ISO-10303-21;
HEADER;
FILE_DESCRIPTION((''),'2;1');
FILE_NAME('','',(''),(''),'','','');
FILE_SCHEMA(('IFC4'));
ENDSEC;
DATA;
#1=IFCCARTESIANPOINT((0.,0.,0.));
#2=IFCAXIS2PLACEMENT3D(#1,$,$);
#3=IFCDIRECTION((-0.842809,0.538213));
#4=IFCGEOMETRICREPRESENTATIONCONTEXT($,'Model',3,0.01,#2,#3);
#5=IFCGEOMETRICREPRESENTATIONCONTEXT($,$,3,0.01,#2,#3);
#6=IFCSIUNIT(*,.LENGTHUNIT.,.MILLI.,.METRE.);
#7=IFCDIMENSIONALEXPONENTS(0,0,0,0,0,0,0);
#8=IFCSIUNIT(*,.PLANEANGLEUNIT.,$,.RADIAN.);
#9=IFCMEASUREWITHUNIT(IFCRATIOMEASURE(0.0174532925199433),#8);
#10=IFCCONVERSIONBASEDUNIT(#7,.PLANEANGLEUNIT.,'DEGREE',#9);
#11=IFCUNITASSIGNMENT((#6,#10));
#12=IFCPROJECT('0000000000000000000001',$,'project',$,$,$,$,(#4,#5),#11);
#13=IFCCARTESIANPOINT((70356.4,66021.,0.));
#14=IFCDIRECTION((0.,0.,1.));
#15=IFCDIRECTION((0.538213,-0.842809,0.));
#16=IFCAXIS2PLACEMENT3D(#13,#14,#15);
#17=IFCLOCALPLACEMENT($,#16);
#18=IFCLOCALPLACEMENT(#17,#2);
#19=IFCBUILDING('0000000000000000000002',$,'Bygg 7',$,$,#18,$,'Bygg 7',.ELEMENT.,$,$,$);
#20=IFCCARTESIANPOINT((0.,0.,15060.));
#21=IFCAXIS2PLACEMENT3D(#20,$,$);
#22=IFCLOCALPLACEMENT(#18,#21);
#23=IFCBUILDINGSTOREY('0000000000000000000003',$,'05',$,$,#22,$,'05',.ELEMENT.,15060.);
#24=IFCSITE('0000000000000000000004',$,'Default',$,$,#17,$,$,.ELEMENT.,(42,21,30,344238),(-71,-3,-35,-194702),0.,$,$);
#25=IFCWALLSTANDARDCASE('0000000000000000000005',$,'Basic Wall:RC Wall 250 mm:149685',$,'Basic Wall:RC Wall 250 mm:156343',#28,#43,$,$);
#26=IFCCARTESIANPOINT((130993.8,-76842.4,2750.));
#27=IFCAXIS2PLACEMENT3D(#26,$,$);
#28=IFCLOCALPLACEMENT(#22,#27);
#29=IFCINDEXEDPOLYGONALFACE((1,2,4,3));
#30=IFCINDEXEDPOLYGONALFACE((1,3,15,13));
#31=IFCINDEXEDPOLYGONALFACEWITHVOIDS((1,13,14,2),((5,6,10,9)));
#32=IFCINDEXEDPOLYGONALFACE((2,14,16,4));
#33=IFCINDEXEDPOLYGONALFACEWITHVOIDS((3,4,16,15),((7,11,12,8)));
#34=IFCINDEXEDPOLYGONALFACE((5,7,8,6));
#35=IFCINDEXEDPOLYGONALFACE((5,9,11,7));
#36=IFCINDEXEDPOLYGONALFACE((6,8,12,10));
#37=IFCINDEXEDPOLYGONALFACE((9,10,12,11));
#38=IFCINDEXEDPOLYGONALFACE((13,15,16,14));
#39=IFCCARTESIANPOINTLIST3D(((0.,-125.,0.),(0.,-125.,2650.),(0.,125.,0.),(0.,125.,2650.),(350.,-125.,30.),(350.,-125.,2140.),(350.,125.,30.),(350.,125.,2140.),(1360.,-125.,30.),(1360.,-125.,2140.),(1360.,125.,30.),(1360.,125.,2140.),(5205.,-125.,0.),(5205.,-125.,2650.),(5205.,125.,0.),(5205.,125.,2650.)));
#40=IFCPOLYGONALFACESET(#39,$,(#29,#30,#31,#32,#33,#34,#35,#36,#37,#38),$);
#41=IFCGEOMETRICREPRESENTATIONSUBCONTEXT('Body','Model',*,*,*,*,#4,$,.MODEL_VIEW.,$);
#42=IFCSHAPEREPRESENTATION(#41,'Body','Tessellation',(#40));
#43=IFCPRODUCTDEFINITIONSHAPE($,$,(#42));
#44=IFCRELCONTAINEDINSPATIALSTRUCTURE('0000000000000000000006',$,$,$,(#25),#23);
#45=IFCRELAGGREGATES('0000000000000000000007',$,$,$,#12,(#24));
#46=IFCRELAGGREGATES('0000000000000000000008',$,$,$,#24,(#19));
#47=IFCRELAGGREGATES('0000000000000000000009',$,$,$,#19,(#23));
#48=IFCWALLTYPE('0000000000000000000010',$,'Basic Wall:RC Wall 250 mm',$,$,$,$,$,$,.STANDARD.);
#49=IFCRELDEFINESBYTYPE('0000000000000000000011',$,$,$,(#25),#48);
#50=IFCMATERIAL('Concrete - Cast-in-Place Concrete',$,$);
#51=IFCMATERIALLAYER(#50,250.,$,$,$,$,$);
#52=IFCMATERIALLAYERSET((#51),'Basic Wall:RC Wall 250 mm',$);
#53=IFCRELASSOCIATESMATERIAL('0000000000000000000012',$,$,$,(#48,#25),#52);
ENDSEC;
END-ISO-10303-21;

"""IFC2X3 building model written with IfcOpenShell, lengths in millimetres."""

from ifc_helpers import new_model, entity, si_unit, converted_unit, direction, frame, frame_2d, origin, origin_2d_with_axis, place, context, subcontext, project, spatial, polyline, rectangle, extrude, clip, bounded_halfspace, material, layer, layer_set, layer_usage, type_object, element, save


model = new_model("IFC2X3")

# Units and contexts
model_context = context("Model", 3, precision=0.01, world=origin(), true_north=direction((-0.842809, 0.538213)))
context_of_model = context(None, 3, precision=0.01, world=origin(), true_north=direction((-0.842809, 0.538213)))
body_context = subcontext(model_context, "Body", "Model", "MODEL_VIEW")
ifc_project = project(units=[si_unit("LENGTHUNIT", "METRE", prefix="MILLI"), converted_unit("PLANEANGLEUNIT", "DEGREE", entity("IfcRatioMeasure", 0.0174532925199433), si_unit("PLANEANGLEUNIT", "RADIAN"), dimensions=[0, 0, 0, 0, 0, 0, 0])], contexts=[model_context, context_of_model])

# Site, building, storey
site_placement = place(None, frame((70356.4, 66021.0, 0.0), z_axis=(0.0, 0.0, 1.0), x_axis=(0.538213, -0.842809, 0.0)))
site = spatial("IfcSite", under=ifc_project, at=site_placement, Name="Default", CompositionType="ELEMENT", RefLatitude=(42, 21, 30, 344238), RefLongitude=(-71, -3, -35, -194702), RefElevation=0.0)
building_placement = place(site_placement, origin())
building = spatial("IfcBuilding", under=site, at=building_placement, Name="Bygg 7", LongName="Bygg 7", CompositionType="ELEMENT")
storey_placement = place(building_placement, frame((0.0, 0.0, 15060.0)))
storey = spatial("IfcBuildingStorey", under=building, at=storey_placement, Name="05", LongName="05", CompositionType="ELEMENT", Elevation=15060.0)

# Shared definitions
ifc_material_1 = material(Name="Concrete - Cast-in-Place Concrete")

# Wall, opening
ifc_layer_1 = layer(ifc_material_1, 250.0)
ifc_layer_set_1 = layer_set([ifc_layer_1], Name="Basic Wall:RC Wall 250 mm")
ifc_layer_usage_1 = layer_usage(ifc_layer_set_1, "AXIS2", "NEGATIVE", 125.0)
wall_type_1 = type_object("IfcWallType", Name="Basic Wall:RC Wall 250 mm", PredefinedType="STANDARD", material=ifc_layer_set_1)
wall_1_placement = place(storey_placement, frame((130993.8, -76842.4, 2750.0)))
wall_1 = element("IfcWallStandardCase", 1, at=wall_1_placement, inside=storey, type_object=wall_type_1, material=ifc_layer_usage_1, Name="Basic Wall:RC Wall 250 mm:149685", ObjectType="Basic Wall:RC Wall 250 mm:156343", context=body_context, shape_type="Clipping", body=[
    clip(clip(extrude(rectangle(XDim=5205.0, YDim=250.0, at=frame_2d((2602.5, 0.0), x_axis=(-1.0, 0.0))), origin(), (0.0, 0.0, 1.0), 2650.0), bounded_halfspace(frame((0.0, -125.0, 2650.0), z_axis=(0.0, 0.0, -1.0), x_axis=(0.092529, -0.99571, 0.0)), True, frame((0.0, -125.0, 2650.0)), polyline([(0.0, 0.0), (220.0, 0.0), (4985.0, 0.0), (5205.0, 0.0), (5205.0, 250.0), (4955.0, 250.0), (250.0, 250.0), (0.0, 250.0), (0.0, 0.0)]))), bounded_halfspace(frame((5205.0, -125.0, 0.0), z_axis=(0.0, 0.0, 1.0), x_axis=(-0.092529, 0.99571, 0.0)), True, frame((5205.0, -125.0, 0.0)), polyline([(0.0, 0.0), (0.0, 250.0), (-250.0, 250.0), (-4955.0, 250.0), (-5205.0, 250.0), (-5205.0, 0.0), (-4985.0, 0.0), (-2974.0, 0.0), (-220.0, 0.0), (0.0, 0.0)]))),
])
opening_1_placement = place(wall_1_placement, origin())
element("IfcOpeningElement", 2, at=opening_1_placement, cuts=wall_1, ObjectType="Opening", context=body_context, shape_type="SweptSolid", body=[
    extrude(rectangle(XDim=2110.0, YDim=1010.0, at=origin_2d_with_axis()), frame((855.0, -125.0, 1085.0), z_axis=(0.0, 1.0, 0.0), x_axis=(0.0, 0.0, -1.0)), (0.0, 0.0, 1.0), 250.0),
])

save(model, "model.ifc")
